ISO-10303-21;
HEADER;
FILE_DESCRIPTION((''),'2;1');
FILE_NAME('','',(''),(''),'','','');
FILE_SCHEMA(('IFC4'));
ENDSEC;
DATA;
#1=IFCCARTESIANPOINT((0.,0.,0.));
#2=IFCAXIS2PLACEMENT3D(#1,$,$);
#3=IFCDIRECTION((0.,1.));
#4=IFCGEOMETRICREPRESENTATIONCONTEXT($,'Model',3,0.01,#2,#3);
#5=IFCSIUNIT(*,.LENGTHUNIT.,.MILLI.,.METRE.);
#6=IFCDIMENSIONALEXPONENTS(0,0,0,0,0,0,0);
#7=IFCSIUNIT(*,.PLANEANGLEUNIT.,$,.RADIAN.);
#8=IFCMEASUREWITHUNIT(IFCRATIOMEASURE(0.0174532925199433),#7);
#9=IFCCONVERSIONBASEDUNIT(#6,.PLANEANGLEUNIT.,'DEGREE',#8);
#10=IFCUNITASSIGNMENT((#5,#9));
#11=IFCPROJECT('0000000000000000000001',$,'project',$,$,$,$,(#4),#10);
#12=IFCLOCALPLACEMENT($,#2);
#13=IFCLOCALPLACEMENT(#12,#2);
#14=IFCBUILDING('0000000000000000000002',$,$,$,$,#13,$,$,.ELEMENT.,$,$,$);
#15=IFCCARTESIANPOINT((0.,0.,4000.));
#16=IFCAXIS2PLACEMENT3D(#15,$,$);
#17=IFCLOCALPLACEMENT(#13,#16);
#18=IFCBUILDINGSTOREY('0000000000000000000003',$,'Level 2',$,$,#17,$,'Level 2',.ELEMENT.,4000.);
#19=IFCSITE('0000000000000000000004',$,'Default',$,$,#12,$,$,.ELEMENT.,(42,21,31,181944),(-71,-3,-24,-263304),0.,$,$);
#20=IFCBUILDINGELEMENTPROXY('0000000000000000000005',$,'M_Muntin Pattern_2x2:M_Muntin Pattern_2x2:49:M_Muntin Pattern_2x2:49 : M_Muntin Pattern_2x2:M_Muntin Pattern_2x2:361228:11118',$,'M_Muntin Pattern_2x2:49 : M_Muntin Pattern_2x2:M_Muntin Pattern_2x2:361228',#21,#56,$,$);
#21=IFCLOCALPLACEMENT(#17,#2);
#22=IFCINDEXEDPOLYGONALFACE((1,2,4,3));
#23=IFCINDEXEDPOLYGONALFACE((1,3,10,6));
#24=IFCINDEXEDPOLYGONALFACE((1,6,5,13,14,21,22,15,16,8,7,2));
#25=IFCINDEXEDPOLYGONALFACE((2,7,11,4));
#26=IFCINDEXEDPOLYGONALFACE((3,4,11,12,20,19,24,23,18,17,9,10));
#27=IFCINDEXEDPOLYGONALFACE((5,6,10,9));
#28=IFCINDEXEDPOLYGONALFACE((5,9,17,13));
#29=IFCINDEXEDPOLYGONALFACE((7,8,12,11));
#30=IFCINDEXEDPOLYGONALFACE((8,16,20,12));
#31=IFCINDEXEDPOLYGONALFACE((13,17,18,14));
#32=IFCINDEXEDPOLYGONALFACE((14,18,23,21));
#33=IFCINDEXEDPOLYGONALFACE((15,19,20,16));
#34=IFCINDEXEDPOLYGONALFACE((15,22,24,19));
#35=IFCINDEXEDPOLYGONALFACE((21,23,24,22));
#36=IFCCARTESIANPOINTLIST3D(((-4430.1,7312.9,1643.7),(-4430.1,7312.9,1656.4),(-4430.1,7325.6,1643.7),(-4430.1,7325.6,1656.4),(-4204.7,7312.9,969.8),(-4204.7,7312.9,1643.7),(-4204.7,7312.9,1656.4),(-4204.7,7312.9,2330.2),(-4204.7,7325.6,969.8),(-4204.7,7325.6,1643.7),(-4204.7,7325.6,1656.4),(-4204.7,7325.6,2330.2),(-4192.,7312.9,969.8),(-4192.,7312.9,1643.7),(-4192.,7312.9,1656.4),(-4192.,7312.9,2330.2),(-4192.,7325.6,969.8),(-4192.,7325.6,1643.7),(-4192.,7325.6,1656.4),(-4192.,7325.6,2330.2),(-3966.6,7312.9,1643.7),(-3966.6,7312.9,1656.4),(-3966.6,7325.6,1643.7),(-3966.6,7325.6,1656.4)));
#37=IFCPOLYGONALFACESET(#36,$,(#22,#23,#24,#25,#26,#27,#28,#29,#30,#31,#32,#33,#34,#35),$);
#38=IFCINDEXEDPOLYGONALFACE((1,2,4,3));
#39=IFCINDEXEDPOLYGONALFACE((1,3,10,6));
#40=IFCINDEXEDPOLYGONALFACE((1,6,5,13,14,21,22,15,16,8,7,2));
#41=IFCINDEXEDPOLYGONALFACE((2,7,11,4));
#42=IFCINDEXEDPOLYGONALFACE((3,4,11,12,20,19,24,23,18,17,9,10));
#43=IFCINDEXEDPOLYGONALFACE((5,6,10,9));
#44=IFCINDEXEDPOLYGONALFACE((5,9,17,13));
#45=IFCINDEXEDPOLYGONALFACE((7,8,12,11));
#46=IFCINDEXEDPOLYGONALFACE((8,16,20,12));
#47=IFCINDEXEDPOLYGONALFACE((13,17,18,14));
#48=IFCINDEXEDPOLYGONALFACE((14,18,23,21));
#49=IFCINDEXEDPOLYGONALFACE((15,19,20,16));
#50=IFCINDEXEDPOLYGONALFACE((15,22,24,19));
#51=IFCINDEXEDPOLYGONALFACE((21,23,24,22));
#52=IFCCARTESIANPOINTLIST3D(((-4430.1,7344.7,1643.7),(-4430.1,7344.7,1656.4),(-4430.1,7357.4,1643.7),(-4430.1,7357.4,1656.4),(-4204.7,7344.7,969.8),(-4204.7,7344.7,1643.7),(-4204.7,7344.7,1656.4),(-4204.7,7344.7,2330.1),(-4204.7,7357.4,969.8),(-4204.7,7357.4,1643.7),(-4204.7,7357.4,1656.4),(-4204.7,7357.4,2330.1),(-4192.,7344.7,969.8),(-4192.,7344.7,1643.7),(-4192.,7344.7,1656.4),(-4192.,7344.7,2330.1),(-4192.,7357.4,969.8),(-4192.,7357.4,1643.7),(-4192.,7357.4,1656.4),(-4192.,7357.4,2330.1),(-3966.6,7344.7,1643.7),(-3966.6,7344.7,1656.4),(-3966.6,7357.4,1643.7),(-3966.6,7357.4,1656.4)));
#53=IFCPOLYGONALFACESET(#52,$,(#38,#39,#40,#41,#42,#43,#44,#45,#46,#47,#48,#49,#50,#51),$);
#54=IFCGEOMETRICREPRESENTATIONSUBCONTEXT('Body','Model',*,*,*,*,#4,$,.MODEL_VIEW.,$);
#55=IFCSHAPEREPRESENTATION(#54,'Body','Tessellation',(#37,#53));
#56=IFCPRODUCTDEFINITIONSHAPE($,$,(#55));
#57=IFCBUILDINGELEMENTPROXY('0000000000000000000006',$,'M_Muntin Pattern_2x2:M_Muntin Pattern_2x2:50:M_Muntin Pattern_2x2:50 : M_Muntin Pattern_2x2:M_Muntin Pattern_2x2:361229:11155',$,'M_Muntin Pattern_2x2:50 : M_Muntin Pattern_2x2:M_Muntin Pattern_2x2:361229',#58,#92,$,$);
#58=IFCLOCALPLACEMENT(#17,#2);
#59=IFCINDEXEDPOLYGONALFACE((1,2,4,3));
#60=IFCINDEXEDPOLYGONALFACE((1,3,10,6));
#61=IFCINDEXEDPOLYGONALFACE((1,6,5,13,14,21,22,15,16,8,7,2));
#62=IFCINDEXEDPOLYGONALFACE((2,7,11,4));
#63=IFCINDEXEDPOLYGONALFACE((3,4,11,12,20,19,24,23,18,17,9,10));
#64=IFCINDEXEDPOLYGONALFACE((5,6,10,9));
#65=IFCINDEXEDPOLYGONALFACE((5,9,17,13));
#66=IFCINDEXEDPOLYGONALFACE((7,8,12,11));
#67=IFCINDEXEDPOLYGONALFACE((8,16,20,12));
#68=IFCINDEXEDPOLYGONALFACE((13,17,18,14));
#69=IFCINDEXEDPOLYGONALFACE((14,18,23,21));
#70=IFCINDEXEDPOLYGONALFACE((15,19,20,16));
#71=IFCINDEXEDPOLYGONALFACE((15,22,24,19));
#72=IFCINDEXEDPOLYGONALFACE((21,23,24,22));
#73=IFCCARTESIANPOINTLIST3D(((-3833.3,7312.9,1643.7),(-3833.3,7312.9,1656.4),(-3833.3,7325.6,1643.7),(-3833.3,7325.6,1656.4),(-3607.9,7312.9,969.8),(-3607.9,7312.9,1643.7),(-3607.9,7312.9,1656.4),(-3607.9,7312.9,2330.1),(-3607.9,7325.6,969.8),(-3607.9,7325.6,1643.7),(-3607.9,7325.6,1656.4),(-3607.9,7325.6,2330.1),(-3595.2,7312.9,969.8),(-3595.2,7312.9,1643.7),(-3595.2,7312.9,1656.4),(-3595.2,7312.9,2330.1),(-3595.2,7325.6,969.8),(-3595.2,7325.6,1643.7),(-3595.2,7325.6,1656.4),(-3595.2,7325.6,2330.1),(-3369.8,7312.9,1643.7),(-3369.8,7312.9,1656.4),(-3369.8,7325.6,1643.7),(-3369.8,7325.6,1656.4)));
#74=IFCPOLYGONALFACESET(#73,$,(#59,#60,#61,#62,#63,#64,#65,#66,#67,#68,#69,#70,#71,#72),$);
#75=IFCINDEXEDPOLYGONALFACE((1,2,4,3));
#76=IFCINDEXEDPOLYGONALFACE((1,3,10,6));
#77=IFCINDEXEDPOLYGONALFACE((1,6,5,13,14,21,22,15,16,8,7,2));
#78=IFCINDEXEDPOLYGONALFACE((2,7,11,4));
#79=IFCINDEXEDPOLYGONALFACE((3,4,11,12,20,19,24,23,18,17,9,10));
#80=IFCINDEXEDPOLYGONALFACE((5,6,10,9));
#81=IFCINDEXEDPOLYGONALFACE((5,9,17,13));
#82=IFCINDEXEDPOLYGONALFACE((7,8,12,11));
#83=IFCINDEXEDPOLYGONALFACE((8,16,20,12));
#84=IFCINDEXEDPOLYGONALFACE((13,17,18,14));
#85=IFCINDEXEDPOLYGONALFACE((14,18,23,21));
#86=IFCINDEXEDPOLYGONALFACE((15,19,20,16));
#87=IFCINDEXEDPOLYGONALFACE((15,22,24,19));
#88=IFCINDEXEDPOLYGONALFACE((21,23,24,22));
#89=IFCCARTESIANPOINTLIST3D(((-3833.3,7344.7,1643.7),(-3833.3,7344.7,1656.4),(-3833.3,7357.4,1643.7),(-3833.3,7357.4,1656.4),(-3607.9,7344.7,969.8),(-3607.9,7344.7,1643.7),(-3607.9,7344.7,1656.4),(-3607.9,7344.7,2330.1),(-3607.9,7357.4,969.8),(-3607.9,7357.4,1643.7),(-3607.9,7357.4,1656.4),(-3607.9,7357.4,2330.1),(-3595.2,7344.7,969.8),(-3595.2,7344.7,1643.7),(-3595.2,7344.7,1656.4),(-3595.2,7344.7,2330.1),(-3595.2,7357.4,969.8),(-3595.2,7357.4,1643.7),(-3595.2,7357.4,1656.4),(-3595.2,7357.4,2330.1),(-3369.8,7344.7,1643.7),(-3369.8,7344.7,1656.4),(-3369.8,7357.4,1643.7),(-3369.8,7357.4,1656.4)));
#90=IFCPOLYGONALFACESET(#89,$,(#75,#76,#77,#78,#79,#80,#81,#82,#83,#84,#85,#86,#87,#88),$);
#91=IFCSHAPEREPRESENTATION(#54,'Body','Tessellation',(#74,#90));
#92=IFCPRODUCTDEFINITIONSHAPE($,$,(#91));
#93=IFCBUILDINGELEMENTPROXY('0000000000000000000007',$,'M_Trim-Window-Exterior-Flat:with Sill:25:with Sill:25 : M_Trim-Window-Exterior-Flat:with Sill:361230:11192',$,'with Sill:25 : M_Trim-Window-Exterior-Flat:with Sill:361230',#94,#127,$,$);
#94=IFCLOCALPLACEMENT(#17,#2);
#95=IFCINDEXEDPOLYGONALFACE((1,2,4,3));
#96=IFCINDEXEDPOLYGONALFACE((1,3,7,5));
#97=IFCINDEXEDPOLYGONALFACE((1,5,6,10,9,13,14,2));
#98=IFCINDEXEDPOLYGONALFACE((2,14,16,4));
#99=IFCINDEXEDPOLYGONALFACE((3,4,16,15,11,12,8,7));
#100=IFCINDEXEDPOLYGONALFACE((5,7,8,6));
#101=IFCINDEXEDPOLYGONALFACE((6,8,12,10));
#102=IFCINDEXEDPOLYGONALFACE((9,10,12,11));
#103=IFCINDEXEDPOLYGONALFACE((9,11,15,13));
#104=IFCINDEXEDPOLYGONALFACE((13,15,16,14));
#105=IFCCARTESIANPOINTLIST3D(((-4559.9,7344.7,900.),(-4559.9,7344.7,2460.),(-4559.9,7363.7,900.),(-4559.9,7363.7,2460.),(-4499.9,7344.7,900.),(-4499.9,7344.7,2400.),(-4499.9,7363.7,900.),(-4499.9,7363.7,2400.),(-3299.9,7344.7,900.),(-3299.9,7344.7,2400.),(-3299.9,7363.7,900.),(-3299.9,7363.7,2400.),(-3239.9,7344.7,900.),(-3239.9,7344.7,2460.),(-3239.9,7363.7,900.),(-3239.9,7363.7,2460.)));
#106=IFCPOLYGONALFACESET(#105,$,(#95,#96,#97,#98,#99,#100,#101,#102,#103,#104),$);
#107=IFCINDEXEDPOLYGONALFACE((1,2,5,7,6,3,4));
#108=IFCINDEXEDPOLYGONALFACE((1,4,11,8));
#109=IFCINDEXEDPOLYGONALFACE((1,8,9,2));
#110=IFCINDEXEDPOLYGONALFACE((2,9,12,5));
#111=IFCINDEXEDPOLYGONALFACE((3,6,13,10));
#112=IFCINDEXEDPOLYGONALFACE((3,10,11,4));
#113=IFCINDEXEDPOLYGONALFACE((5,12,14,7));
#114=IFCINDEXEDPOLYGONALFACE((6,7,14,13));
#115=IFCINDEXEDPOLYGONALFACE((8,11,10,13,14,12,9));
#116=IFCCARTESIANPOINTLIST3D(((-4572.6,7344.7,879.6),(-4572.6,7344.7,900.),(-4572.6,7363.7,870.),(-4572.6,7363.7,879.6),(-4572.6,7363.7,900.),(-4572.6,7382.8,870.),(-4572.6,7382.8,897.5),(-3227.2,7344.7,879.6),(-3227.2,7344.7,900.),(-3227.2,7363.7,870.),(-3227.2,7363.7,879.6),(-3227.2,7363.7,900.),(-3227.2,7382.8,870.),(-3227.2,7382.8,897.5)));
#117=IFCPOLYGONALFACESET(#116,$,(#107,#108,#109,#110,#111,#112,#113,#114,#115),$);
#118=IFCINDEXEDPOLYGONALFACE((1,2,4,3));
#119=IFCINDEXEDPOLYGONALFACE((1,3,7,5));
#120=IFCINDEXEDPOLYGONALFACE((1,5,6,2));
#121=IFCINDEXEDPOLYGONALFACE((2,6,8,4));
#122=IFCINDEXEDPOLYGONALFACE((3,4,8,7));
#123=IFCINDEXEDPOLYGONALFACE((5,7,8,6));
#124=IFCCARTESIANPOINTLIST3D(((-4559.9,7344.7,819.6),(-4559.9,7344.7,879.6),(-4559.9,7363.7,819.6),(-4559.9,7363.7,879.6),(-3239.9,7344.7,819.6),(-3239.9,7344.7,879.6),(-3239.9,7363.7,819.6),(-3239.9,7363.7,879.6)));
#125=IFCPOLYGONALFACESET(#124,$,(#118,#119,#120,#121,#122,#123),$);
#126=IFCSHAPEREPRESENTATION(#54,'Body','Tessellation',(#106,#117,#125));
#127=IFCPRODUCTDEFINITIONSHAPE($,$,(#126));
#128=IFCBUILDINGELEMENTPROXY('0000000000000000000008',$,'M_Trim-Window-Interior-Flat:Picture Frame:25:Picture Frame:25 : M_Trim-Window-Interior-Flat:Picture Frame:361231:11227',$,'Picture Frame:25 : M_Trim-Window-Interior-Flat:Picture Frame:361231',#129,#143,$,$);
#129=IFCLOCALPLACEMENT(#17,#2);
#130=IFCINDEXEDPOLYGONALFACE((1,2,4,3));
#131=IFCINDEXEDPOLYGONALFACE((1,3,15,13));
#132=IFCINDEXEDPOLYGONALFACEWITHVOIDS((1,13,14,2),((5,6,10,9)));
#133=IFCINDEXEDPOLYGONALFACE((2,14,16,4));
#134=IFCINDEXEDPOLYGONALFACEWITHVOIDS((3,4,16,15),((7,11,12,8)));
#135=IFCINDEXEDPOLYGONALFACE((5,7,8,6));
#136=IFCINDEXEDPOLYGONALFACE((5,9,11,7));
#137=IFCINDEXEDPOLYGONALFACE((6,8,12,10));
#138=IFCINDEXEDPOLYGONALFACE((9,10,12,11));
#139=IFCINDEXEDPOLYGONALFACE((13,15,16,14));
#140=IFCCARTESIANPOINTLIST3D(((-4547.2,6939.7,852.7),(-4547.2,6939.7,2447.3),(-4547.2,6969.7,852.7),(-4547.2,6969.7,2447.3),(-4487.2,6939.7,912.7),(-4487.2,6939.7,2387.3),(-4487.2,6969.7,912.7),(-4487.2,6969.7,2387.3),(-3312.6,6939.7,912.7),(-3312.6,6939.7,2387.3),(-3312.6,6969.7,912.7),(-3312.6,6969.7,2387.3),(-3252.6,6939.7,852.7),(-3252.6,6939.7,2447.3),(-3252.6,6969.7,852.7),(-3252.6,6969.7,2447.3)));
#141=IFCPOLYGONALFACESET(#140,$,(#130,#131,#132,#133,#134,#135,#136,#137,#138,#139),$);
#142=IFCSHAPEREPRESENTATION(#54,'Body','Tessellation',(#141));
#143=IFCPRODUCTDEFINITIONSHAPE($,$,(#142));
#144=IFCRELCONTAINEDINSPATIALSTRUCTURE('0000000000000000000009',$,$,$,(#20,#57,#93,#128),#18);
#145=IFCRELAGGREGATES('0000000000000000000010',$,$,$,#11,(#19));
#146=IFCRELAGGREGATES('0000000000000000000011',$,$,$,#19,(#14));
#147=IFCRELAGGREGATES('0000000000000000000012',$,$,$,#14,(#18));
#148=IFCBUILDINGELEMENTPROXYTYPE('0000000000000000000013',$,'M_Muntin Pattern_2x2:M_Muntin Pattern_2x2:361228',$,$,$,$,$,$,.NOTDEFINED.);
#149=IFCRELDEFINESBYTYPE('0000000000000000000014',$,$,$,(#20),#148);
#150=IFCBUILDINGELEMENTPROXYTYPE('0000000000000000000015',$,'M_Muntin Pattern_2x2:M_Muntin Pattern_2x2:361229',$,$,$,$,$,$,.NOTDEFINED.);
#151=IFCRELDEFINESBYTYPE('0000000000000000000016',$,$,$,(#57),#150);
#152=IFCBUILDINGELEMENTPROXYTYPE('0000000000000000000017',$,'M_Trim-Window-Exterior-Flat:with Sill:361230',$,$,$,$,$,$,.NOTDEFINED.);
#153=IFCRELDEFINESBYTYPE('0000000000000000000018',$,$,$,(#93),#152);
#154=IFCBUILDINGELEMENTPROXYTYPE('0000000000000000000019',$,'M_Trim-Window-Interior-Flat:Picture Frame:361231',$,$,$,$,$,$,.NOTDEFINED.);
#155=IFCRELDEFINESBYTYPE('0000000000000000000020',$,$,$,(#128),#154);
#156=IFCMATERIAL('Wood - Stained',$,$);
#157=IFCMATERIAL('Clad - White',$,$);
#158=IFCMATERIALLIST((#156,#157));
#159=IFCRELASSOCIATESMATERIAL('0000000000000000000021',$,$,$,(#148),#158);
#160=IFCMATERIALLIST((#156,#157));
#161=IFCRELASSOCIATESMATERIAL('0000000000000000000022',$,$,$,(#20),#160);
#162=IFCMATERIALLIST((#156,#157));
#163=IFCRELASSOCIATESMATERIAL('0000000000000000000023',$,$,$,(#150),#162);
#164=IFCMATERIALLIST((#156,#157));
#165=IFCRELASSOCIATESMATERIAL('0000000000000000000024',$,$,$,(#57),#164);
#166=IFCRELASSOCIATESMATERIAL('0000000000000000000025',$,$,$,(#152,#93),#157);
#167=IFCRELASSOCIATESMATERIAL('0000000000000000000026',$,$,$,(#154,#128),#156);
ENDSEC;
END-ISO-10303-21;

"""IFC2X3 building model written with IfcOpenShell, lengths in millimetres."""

from ifc_helpers import new_model, entity, si_unit, converted_unit, direction, frame, origin, origin_2d_with_axis, place, context, subcontext, project, spatial, polyline, rectangle, outline, extrude, source, transform, mapped, material, material_list, type_object, type_shapes, element, save


model = new_model("IFC2X3")

# Units and contexts
model_context = context("Model", 3, precision=0.01, world=origin(), true_north=direction((0.0, 1.0)))
body_context = subcontext(model_context, "Body", "Model", "MODEL_VIEW")
ifc_project = project(units=[si_unit("LENGTHUNIT", "METRE", prefix="MILLI"), converted_unit("PLANEANGLEUNIT", "DEGREE", entity("IfcRatioMeasure", 0.0174532925199433), si_unit("PLANEANGLEUNIT", "RADIAN"), dimensions=[0, 0, 0, 0, 0, 0, 0])], contexts=[model_context])

# Site, building, storey
site_placement = place(None, origin())
site = spatial("IfcSite", under=ifc_project, at=site_placement, Name="Default", CompositionType="ELEMENT", RefLatitude=(42, 21, 31, 181944), RefLongitude=(-71, -3, -24, -263304), RefElevation=0.0)
building_placement = place(site_placement, origin())
building = spatial("IfcBuilding", under=site, at=building_placement, CompositionType="ELEMENT")
storey_placement = place(building_placement, frame((0.0, 0.0, 4000.0)))
storey = spatial("IfcBuildingStorey", under=building, at=storey_placement, Name="Level 2", LongName="Level 2", CompositionType="ELEMENT", Elevation=4000.0)

# Building element proxies
ifc_material_1 = material(Name="Wood - Stained")
ifc_material_2 = material(Name="Clad - White")
ifc_material_list_1 = material_list([ifc_material_1, ifc_material_2])
ifc_material_list_2 = material_list([ifc_material_1, ifc_material_2])
building_element_proxy_type_1 = type_object("IfcBuildingElementProxyType", Name="M_Muntin Pattern_2x2:M_Muntin Pattern_2x2:361228", PredefinedType="NOTDEFINED", material=ifc_material_list_2)
shared_shape_1 = source(origin(), body_context, "Body", "SweptSolid", [
    extrude(outline(polyline([(-6.4, -680.2), (6.3, -680.2), (6.3, -6.4), (231.7, -6.4), (231.7, 6.3), (6.3, 6.3), (6.3, 680.2), (-6.4, 680.2), (-6.4, 6.3), (-231.7, 6.3), (-231.7, -6.4), (-6.4, -6.4), (-6.4, -680.2)])), frame((-4198.4, 7312.9, 5650.0), z_axis=(0.0, 1.0, 0.0), x_axis=(1.0, 0.0, 0.0)), (0.0, 0.0, 1.0), 12.7),
    extrude(outline(polyline([(-6.4, -680.1), (6.3, -680.1), (6.3, -6.4), (231.7, -6.4), (231.7, 6.3), (6.3, 6.3), (6.3, 680.2), (-6.4, 680.2), (-6.4, 6.3), (-231.7, 6.3), (-231.7, -6.4), (-6.4, -6.4), (-6.4, -680.1)])), frame((-4198.4, 7344.7, 5650.0), z_axis=(0.0, 1.0, 0.0), x_axis=(1.0, 0.0, 0.0)), (0.0, 0.0, 1.0), 12.7),
])
type_shapes(building_element_proxy_type_1, [shared_shape_1])
proxy_1_placement = place(storey_placement, frame((0.0, 0.0, -4000.0)))
element("IfcBuildingElementProxy", 1, at=proxy_1_placement, inside=storey, type_object=building_element_proxy_type_1, material=ifc_material_list_1, Name="M_Muntin Pattern_2x2:M_Muntin Pattern_2x2:49:M_Muntin Pattern_2x2:49 : M_Muntin Pattern_2x2:M_Muntin Pattern_2x2:361228:11118", ObjectType="M_Muntin Pattern_2x2:49 : M_Muntin Pattern_2x2:M_Muntin Pattern_2x2:361228", context=body_context, shape_type="MappedRepresentation", body=[
    mapped(shared_shape_1, transform((0.0, 0.0, 0.0), scale=1.0)),
])
ifc_material_list_3 = material_list([ifc_material_1, ifc_material_2])
ifc_material_list_4 = material_list([ifc_material_1, ifc_material_2])
building_element_proxy_type_2 = type_object("IfcBuildingElementProxyType", Name="M_Muntin Pattern_2x2:M_Muntin Pattern_2x2:361229", PredefinedType="NOTDEFINED", material=ifc_material_list_4)
shared_shape_2 = source(origin(), body_context, "Body", "SweptSolid", [
    extrude(outline(polyline([(-680.1, 6.4), (-680.1, -6.3), (-6.4, -6.3), (-6.4, -231.7), (6.3, -231.7), (6.3, -6.3), (680.2, -6.3), (680.2, 6.4), (6.3, 6.4), (6.3, 231.7), (-6.4, 231.7), (-6.4, 6.4), (-680.1, 6.4)])), frame((-3601.5, 7312.9, 5650.0), z_axis=(0.0, -1.0, 0.0), x_axis=(0.0, 0.0, -1.0)), (0.0, 0.0, -1.0), 12.7),
    extrude(outline(polyline([(-680.1, 6.4), (-680.1, -6.3), (-6.4, -6.3), (-6.4, -231.7), (6.3, -231.7), (6.3, -6.3), (680.2, -6.3), (680.2, 6.4), (6.3, 6.4), (6.3, 231.7), (-6.4, 231.7), (-6.4, 6.4), (-680.1, 6.4)])), frame((-3601.5, 7344.7, 5650.0), z_axis=(0.0, -1.0, 0.0), x_axis=(0.0, 0.0, -1.0)), (0.0, 0.0, -1.0), 12.7),
])
type_shapes(building_element_proxy_type_2, [shared_shape_2])
proxy_2_placement = place(storey_placement, frame((0.0, 0.0, -4000.0)))
element("IfcBuildingElementProxy", 2, at=proxy_2_placement, inside=storey, type_object=building_element_proxy_type_2, material=ifc_material_list_3, Name="M_Muntin Pattern_2x2:M_Muntin Pattern_2x2:50:M_Muntin Pattern_2x2:50 : M_Muntin Pattern_2x2:M_Muntin Pattern_2x2:361229:11155", ObjectType="M_Muntin Pattern_2x2:50 : M_Muntin Pattern_2x2:M_Muntin Pattern_2x2:361229", context=body_context, shape_type="MappedRepresentation", body=[
    mapped(shared_shape_2, transform((0.0, 0.0, 0.0), scale=1.0)),
])
building_element_proxy_type_3 = type_object("IfcBuildingElementProxyType", Name="M_Trim-Window-Exterior-Flat:with Sill:361230", PredefinedType="NOTDEFINED", material=ifc_material_2)
shared_shape_3 = source(origin(), body_context, "Body", "SweptSolid", [
    extrude(outline(polyline([(-660.0, -765.0), (-600.0, -765.0), (-600.0, 735.0), (600.0, 735.0), (600.0, -765.0), (660.0, -765.0), (660.0, 795.0), (-660.0, 795.0), (-660.0, -765.0)])), frame((-3899.9, 7344.7, 5665.0), z_axis=(0.0, 1.0, 0.0), x_axis=(-1.0, 0.0, 0.0)), (0.0, 0.0, 1.0), 19.1),
    extrude(outline(polyline([(0.0, -15.2), (19.0, -15.2), (19.0, 12.3), (0.0, 14.8), (-19.0, 14.8), (-19.0, -5.7), (0.0, -5.7), (0.0, -15.2)])), frame((-4572.6, 7363.7, 4885.2), z_axis=(1.0, 0.0, 0.0), x_axis=(0.0, 1.0, 0.0)), (0.0, 0.0, 1.0), 1345.4),
    extrude(rectangle(XDim=19.1, YDim=1320.0, at=origin_2d_with_axis()), frame((-3899.9, 7354.2, 4819.6), z_axis=(0.0, 0.0, 1.0), x_axis=(0.0, -1.0, 0.0)), (0.0, 0.0, 1.0), 60.0),
])
type_shapes(building_element_proxy_type_3, [shared_shape_3])
proxy_3_placement = place(storey_placement, frame((0.0, 0.0, -4000.0)))
element("IfcBuildingElementProxy", 3, at=proxy_3_placement, inside=storey, type_object=building_element_proxy_type_3, material=ifc_material_2, Name="M_Trim-Window-Exterior-Flat:with Sill:25:with Sill:25 : M_Trim-Window-Exterior-Flat:with Sill:361230:11192", ObjectType="with Sill:25 : M_Trim-Window-Exterior-Flat:with Sill:361230", context=body_context, shape_type="MappedRepresentation", body=[
    mapped(shared_shape_3, transform((0.0, 0.0, 0.0), scale=1.0)),
])
building_element_proxy_type_4 = type_object("IfcBuildingElementProxyType", Name="M_Trim-Window-Interior-Flat:Picture Frame:361231", PredefinedType="NOTDEFINED", material=ifc_material_1)
shared_shape_4 = source(origin(), body_context, "Body", "SweptSolid", [
    extrude(outline(polyline([(-647.3, -797.3), (647.3, -797.3), (647.3, 797.3), (-647.3, 797.3), (-647.3, -797.3)]), holes=[polyline([(587.3, 737.3), (587.3, -737.3), (-587.3, -737.3), (-587.3, 737.3), (587.3, 737.3)])]), frame((-3899.9, 6939.7, 5650.0), z_axis=(0.0, 1.0, 0.0), x_axis=(1.0, 0.0, 0.0)), (0.0, 0.0, 1.0), 30.0),
])
type_shapes(building_element_proxy_type_4, [shared_shape_4])
proxy_4_placement = place(storey_placement, frame((0.0, 0.0, -4000.0)))
element("IfcBuildingElementProxy", 4, at=proxy_4_placement, inside=storey, type_object=building_element_proxy_type_4, material=ifc_material_1, Name="M_Trim-Window-Interior-Flat:Picture Frame:25:Picture Frame:25 : M_Trim-Window-Interior-Flat:Picture Frame:361231:11227", ObjectType="Picture Frame:25 : M_Trim-Window-Interior-Flat:Picture Frame:361231", context=body_context, shape_type="MappedRepresentation", body=[
    mapped(shared_shape_4, transform((0.0, 0.0, 0.0), scale=1.0)),
])

save(model, "model.ifc")
